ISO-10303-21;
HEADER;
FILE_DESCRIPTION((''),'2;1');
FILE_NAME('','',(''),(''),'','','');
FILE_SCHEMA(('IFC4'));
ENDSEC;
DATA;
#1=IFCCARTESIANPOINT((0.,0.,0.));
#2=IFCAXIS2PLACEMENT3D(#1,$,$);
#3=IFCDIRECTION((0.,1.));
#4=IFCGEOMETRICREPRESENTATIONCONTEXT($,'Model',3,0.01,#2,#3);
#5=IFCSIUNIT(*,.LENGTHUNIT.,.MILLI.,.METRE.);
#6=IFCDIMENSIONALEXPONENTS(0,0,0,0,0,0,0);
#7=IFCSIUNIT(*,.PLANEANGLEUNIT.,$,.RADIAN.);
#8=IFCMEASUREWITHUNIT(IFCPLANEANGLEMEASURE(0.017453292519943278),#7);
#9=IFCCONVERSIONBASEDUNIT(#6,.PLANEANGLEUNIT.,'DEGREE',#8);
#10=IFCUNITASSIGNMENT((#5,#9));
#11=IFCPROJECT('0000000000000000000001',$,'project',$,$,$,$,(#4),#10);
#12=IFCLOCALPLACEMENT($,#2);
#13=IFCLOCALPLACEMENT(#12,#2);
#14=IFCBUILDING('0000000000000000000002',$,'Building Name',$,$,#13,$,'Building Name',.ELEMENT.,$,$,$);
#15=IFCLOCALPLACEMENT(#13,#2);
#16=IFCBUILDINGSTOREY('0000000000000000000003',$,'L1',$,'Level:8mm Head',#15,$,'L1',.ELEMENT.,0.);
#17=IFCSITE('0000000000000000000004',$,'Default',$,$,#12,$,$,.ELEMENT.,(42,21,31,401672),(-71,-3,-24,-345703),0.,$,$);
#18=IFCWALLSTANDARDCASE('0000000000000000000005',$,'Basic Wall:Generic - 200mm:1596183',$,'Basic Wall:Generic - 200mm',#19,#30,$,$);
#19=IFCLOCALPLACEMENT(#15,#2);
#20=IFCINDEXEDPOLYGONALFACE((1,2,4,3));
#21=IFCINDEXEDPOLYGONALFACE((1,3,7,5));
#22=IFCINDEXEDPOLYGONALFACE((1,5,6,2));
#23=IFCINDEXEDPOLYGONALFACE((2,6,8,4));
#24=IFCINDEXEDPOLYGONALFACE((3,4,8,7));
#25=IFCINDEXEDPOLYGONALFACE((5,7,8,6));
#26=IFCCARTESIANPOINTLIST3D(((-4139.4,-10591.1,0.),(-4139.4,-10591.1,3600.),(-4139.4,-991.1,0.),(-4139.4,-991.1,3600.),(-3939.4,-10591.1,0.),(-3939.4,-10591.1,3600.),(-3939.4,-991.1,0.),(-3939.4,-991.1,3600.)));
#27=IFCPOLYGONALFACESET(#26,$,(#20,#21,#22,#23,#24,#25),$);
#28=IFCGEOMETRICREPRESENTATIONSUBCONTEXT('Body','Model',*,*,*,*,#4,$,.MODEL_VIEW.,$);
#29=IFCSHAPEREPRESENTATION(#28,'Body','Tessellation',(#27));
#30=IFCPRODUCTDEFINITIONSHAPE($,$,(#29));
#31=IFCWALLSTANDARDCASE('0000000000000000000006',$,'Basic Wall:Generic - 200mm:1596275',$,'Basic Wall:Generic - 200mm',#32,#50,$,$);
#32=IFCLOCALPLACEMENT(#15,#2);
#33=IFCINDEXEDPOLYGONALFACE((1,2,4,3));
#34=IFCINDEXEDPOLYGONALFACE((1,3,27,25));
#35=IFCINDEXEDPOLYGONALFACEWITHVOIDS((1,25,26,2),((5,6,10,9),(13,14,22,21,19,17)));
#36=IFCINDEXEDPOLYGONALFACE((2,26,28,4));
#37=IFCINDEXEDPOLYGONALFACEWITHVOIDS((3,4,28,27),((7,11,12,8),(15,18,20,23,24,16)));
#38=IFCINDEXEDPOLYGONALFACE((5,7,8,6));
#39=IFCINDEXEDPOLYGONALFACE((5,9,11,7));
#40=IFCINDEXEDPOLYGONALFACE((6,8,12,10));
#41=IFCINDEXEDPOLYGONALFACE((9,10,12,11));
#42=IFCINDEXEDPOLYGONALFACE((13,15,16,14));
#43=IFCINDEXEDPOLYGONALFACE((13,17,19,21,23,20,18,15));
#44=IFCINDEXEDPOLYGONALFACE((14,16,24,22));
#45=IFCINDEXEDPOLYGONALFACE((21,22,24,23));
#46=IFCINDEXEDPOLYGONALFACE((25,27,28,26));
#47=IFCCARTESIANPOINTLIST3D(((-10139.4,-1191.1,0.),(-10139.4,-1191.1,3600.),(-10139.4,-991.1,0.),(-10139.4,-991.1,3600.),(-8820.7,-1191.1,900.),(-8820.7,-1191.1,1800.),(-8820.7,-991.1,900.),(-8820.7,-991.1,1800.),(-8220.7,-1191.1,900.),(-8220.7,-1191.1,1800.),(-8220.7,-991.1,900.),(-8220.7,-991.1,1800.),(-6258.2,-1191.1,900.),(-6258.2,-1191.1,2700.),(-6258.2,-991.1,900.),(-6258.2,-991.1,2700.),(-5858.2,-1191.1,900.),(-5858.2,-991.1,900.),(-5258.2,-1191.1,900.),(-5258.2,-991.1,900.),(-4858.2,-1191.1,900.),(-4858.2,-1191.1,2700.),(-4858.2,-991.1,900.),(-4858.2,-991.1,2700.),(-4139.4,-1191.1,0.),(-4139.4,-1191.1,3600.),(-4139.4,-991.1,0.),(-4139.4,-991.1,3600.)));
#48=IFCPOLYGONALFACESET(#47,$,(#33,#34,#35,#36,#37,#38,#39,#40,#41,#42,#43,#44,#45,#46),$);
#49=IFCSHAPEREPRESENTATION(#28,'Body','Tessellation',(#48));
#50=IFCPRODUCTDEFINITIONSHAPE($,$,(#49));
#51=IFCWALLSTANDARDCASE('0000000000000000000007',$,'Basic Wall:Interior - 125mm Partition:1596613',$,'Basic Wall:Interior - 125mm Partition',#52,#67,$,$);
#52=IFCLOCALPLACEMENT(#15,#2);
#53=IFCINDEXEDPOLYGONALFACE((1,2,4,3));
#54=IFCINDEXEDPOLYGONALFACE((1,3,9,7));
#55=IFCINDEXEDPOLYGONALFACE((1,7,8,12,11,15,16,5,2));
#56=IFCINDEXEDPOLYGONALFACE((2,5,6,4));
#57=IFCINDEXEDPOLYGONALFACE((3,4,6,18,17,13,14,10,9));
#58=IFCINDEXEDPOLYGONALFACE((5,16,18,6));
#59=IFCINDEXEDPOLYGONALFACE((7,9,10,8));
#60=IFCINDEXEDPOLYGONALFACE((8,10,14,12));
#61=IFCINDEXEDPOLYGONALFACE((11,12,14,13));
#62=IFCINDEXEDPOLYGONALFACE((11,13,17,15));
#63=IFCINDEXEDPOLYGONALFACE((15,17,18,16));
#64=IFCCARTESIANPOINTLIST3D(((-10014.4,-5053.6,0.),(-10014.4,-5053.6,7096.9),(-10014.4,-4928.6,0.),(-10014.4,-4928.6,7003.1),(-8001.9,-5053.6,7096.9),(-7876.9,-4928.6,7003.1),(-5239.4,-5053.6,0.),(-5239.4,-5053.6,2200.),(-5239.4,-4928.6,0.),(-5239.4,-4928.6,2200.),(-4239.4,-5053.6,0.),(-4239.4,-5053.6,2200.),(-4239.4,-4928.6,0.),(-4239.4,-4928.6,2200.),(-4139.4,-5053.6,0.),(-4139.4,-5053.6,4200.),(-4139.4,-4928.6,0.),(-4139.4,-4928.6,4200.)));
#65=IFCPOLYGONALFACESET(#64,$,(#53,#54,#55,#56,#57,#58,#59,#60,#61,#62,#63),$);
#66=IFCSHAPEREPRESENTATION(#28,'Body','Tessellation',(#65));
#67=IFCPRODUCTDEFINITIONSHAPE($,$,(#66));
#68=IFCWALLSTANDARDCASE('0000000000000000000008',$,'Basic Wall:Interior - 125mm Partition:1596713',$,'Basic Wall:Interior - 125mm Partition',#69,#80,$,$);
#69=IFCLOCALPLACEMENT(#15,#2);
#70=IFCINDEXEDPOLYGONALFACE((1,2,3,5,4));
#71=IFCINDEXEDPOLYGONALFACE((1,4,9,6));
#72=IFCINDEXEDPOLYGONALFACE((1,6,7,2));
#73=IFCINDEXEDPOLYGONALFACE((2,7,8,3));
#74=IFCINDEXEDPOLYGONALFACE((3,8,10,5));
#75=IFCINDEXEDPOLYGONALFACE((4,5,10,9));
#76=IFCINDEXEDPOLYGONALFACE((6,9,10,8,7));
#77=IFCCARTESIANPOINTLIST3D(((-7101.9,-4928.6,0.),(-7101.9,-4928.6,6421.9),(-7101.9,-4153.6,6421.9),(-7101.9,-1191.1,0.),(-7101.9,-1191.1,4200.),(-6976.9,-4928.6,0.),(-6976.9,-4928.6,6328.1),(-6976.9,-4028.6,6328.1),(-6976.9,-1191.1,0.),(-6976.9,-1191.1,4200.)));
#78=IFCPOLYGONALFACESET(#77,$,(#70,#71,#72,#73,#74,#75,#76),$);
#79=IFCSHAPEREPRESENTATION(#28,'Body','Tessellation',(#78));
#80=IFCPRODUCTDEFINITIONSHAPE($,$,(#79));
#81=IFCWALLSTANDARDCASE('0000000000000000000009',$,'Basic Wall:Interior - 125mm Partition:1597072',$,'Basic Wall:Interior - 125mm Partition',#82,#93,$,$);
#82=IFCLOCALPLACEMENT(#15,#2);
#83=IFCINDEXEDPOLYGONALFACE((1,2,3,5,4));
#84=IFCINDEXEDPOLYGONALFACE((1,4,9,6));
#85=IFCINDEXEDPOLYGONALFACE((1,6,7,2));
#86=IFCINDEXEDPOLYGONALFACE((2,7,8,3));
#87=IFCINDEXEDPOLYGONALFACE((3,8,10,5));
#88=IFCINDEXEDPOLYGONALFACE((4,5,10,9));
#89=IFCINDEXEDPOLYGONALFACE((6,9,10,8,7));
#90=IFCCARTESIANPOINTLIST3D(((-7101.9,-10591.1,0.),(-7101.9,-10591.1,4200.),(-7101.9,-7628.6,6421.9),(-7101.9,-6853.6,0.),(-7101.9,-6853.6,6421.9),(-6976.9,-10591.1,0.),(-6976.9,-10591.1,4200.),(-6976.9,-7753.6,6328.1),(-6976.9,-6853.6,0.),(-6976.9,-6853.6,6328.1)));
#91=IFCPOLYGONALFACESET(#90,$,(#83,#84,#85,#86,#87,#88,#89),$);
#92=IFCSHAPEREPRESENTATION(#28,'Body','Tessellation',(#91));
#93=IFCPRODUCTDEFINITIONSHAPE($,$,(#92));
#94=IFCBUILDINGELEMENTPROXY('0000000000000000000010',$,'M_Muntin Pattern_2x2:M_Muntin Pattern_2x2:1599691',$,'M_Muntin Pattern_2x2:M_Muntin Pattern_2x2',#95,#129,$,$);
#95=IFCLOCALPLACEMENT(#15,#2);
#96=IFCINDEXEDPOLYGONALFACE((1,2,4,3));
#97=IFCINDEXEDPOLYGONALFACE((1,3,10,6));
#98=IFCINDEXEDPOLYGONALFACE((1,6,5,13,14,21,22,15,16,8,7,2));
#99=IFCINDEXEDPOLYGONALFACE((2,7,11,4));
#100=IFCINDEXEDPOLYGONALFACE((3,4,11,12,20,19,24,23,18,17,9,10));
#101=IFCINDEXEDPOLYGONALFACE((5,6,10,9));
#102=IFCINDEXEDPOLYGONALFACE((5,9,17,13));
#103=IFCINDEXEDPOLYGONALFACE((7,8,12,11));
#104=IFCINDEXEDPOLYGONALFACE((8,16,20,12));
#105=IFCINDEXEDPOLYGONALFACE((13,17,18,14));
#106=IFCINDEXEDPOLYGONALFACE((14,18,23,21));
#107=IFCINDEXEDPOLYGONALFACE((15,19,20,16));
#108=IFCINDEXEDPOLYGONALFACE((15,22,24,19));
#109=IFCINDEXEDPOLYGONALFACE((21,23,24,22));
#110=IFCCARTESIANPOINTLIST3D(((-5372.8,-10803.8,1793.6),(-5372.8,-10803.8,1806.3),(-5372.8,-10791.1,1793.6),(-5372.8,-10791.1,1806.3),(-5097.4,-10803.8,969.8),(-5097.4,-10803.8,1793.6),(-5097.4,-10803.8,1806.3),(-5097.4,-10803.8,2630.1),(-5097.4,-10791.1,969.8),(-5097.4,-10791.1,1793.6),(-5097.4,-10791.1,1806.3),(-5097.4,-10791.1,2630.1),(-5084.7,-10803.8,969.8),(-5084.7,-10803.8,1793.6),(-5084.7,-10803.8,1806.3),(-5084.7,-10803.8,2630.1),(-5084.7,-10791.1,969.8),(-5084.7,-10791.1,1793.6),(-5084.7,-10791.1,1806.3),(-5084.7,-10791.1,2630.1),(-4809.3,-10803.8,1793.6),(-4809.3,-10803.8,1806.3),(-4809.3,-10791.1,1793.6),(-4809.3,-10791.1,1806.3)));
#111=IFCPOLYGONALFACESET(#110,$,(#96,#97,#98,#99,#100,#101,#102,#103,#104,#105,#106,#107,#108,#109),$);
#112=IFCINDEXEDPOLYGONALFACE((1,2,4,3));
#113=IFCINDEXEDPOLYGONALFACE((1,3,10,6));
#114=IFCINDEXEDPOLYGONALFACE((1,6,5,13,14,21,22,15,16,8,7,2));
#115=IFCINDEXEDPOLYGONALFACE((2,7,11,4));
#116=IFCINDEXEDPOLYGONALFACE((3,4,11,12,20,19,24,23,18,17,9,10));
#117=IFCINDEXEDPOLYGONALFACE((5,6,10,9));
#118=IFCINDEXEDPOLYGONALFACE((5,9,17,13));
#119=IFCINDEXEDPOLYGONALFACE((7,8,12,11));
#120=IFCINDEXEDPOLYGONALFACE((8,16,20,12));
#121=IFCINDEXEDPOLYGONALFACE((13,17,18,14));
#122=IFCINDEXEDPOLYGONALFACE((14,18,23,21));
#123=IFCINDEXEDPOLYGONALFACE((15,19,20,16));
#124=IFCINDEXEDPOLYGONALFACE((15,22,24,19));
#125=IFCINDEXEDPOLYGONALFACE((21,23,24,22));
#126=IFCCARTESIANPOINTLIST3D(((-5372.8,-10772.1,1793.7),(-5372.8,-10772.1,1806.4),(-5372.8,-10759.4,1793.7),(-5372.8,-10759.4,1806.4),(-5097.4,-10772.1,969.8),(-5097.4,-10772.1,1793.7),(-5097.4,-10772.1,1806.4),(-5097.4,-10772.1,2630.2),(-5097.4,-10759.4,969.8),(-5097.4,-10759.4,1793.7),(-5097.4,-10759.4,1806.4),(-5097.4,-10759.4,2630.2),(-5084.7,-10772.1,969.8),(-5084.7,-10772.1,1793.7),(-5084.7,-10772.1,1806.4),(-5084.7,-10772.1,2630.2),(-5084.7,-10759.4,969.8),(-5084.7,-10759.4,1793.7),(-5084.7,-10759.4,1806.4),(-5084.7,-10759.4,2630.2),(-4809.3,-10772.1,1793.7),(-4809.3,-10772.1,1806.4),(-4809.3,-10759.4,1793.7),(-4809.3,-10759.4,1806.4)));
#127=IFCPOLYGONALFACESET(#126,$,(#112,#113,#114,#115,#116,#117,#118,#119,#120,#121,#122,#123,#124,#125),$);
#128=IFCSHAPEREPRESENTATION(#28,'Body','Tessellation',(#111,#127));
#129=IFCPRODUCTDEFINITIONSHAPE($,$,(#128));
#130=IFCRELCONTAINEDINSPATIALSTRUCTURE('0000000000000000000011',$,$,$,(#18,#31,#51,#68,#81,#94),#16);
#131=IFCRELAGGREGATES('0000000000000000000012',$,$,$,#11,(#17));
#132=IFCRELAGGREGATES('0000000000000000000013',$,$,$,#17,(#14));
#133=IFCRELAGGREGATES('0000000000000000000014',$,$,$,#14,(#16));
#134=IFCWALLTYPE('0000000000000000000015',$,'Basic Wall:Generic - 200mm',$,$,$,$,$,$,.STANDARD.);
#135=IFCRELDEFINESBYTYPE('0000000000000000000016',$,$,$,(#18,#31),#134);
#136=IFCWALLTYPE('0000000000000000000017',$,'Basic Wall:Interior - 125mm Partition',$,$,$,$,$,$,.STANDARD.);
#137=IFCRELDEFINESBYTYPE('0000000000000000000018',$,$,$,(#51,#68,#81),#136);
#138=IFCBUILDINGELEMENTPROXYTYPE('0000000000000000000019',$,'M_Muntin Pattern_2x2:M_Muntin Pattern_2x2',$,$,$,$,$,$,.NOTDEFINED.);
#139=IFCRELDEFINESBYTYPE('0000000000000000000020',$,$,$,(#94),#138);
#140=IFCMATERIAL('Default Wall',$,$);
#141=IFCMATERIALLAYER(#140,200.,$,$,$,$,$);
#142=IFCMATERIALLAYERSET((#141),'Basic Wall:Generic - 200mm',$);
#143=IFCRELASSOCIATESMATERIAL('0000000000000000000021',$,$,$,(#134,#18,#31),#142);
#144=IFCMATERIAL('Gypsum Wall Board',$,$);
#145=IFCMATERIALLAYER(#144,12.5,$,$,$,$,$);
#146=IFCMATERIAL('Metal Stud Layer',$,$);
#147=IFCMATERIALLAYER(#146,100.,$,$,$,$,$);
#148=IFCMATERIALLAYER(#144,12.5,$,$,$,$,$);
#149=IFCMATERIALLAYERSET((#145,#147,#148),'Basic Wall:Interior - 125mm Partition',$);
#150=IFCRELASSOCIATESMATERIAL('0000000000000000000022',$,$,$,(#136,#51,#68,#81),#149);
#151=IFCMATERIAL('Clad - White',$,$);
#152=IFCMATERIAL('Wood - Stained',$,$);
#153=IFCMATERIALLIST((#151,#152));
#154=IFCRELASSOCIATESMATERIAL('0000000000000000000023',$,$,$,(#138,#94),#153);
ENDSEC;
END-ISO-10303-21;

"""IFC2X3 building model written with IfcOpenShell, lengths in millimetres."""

from ifc_helpers import new_model, entity, si_unit, converted_unit, direction, frame, frame_2d, origin, place, context, subcontext, project, spatial, polyline, rectangle, outline, extrude, clip, bounded_halfspace, source, transform, mapped, material, material_list, layer, layer_set, layer_usage, type_object, type_shapes, element, save


model = new_model("IFC2X3")

# Units and contexts
model_context = context("Model", 3, precision=0.01, world=origin(), true_north=direction((0.0, 1.0)))
body_context = subcontext(model_context, "Body", "Model", "MODEL_VIEW")
ifc_project = project(units=[si_unit("LENGTHUNIT", "METRE", prefix="MILLI"), converted_unit("PLANEANGLEUNIT", "DEGREE", entity("IfcPlaneAngleMeasure", 0.017453292519943278), si_unit("PLANEANGLEUNIT", "RADIAN"), dimensions=[0, 0, 0, 0, 0, 0, 0])], contexts=[model_context])

# Site, building, storey
site_placement = place(None, origin())
site = spatial("IfcSite", under=ifc_project, at=site_placement, Name="Default", CompositionType="ELEMENT", RefLatitude=(42, 21, 31, 401672), RefLongitude=(-71, -3, -24, -345703), RefElevation=0.0)
building_placement = place(site_placement, origin())
building = spatial("IfcBuilding", under=site, at=building_placement, Name="Building Name", LongName="Building Name", CompositionType="ELEMENT")
storey_placement = place(building_placement, origin())
storey = spatial("IfcBuildingStorey", under=building, at=storey_placement, Name="L1", ObjectType="Level:8mm Head", LongName="L1", CompositionType="ELEMENT", Elevation=0.0)

# Wall
ifc_material_1 = material(Name="Default Wall")
ifc_layer_1 = layer(ifc_material_1, 200.0)
ifc_layer_set_1 = layer_set([ifc_layer_1], Name="Basic Wall:Generic - 200mm")
ifc_layer_usage_1 = layer_usage(ifc_layer_set_1, "AXIS2", "NEGATIVE", 100.0)
wall_type_1 = type_object("IfcWallType", Name="Basic Wall:Generic - 200mm", PredefinedType="STANDARD", material=ifc_layer_set_1)
wall_1_placement = place(storey_placement, frame((-4039.4, -10591.1, 0.0), z_axis=(0.0, 0.0, 1.0), x_axis=(0.0, 1.0, 0.0)))
element("IfcWallStandardCase", 1, at=wall_1_placement, inside=storey, type_object=wall_type_1, material=ifc_layer_usage_1, Name="Basic Wall:Generic - 200mm:1596183", ObjectType="Basic Wall:Generic - 200mm", context=body_context, shape_type="SweptSolid", body=[
    extrude(rectangle(XDim=9600.0, YDim=200.0, at=frame_2d((4800.0, 0.0), x_axis=(-1.0, 0.0))), origin(), (0.0, 0.0, 1.0), 3600.0),
])

# Wall, openings
wall_2_placement = place(storey_placement, frame((-4139.4, -1091.1, 0.0), z_axis=(0.0, 0.0, 1.0), x_axis=(-1.0, 0.0, 0.0)))
wall_2 = element("IfcWallStandardCase", 2, at=wall_2_placement, inside=storey, type_object=wall_type_1, material=ifc_layer_usage_1, Name="Basic Wall:Generic - 200mm:1596275", ObjectType="Basic Wall:Generic - 200mm", context=body_context, shape_type="SweptSolid", body=[
    extrude(rectangle(XDim=6000.0, YDim=200.0, at=frame_2d((3000.0, 0.0), x_axis=(-1.0, 0.0))), origin(), (0.0, 0.0, 1.0), 3600.0),
])
opening_1_placement = place(wall_2_placement, frame((2118.8, 100.0, 900.0)))
element("IfcOpeningElement", 3, at=opening_1_placement, cuts=wall_2, ObjectType="Opening", context=body_context, shape_type="SweptSolid", body=[
    extrude(rectangle(XDim=1800.0, YDim=1400.0, at=frame_2d((900.0, 700.0), x_axis=(-1.0, 0.0))), frame((0.0, 0.0, 0.0), z_axis=(0.0, -1.0, 0.0), x_axis=(0.0, 0.0, 1.0)), (0.0, 0.0, 1.0), 200.0),
])
opening_2_placement = place(wall_2_placement, frame((1118.8, -100.0, 900.0)))
element("IfcOpeningElement", 4, at=opening_2_placement, cuts=wall_2, ObjectType="Opening", context=body_context, shape_type="SweptSolid", body=[
    extrude(rectangle(XDim=900.0, YDim=600.0, at=frame_2d((450.0, 300.0), x_axis=(-1.0, 0.0))), frame((0.0, 0.0, 0.0), z_axis=(0.0, 1.0, 0.0), x_axis=(0.0, 0.0, 1.0)), (0.0, 0.0, 1.0), 200.0),
])
opening_3_placement = place(wall_2_placement, frame((4081.3, -100.0, 900.0)))
element("IfcOpeningElement", 5, at=opening_3_placement, cuts=wall_2, ObjectType="Opening", context=body_context, shape_type="SweptSolid", body=[
    extrude(rectangle(XDim=900.0, YDim=600.0, at=frame_2d((450.0, 300.0), x_axis=(-1.0, 0.0))), frame((0.0, 0.0, 0.0), z_axis=(0.0, 1.0, 0.0), x_axis=(0.0, 0.0, 1.0)), (0.0, 0.0, 1.0), 200.0),
])

# Wall, opening
ifc_material_2 = material(Name="Gypsum Wall Board")
ifc_layer_2 = layer(ifc_material_2, 12.5)
ifc_material_3 = material(Name="Metal Stud Layer")
ifc_layer_3 = layer(ifc_material_3, 100.0)
ifc_layer_4 = layer(ifc_material_2, 12.5)
ifc_layer_set_2 = layer_set([ifc_layer_2, ifc_layer_3, ifc_layer_4], Name="Basic Wall:Interior - 125mm Partition")
ifc_layer_usage_2 = layer_usage(ifc_layer_set_2, "AXIS2", "NEGATIVE", 62.5)
wall_type_2 = type_object("IfcWallType", Name="Basic Wall:Interior - 125mm Partition", PredefinedType="STANDARD", material=ifc_layer_set_2)
wall_3_placement = place(storey_placement, frame((-10014.4, -4991.1, 0.0)))
wall_3 = element("IfcWallStandardCase", 6, at=wall_3_placement, inside=storey, type_object=wall_type_2, material=ifc_layer_usage_2, Name="Basic Wall:Interior - 125mm Partition:1596613", ObjectType="Basic Wall:Interior - 125mm Partition", context=body_context, shape_type="Clipping", body=[
    clip(clip(extrude(rectangle(XDim=125.0, YDim=5875.0, at=frame_2d((2937.5, 0.0), x_axis=(0.0, 1.0))), origin(), (0.0, 0.0, 1.0), 7096.9), bounded_halfspace(frame((5875.0, -62.5, 4200.0), z_axis=(0.6, 0.0, 0.8), x_axis=(0.0, 1.0, 0.0)), False, frame((5875.0, -62.5, 4200.0)), polyline([(0.0, 0.0), (0.0, 125.0), (-2837.5, 125.0), (-2962.5, 125.0), (-3737.5, 125.0), (-3862.5, 0.0), (0.0, 0.0)]))), bounded_halfspace(frame((0.0, 62.5, 7003.1), z_axis=(0.0, 0.6, 0.8), x_axis=(-1.0, 0.0, 0.0)), False, frame((0.0, 62.5, 7003.1)), polyline([(0.0, 0.0), (0.0, -125.0), (2012.5, -125.0), (2137.5, 0.0), (0.0, 0.0)]))),
])
opening_4_placement = place(wall_3_placement, frame((4775.0, -62.5, 0.0)))
element("IfcOpeningElement", 7, at=opening_4_placement, cuts=wall_3, ObjectType="Opening", context=body_context, shape_type="SweptSolid", body=[
    extrude(rectangle(XDim=2200.0, YDim=1000.0, at=frame_2d((1100.0, 500.0), x_axis=(1.0, 0.0))), frame((0.0, 0.0, 0.0), z_axis=(0.0, 1.0, 0.0), x_axis=(0.0, 0.0, 1.0)), (0.0, 0.0, 1.0), 125.0),
])

# Walls
wall_4_placement = place(storey_placement, frame((-7039.4, -4928.6, 0.0), z_axis=(0.0, 0.0, 1.0), x_axis=(0.0, 1.0, 0.0)))
element("IfcWallStandardCase", 8, at=wall_4_placement, inside=storey, type_object=wall_type_2, material=ifc_layer_usage_2, Name="Basic Wall:Interior - 125mm Partition:1596713", ObjectType="Basic Wall:Interior - 125mm Partition", context=body_context, shape_type="Clipping", body=[
    clip(clip(extrude(rectangle(XDim=3737.5, YDim=125.0, at=frame_2d((1868.8, 0.0), x_axis=(-1.0, 0.0))), origin(), (0.0, 0.0, 1.0), 6421.9), bounded_halfspace(frame((0.0, -62.5, 6328.1), z_axis=(0.0, -0.6, 0.8), x_axis=(1.0, 0.0, 0.0)), False, frame((0.0, -62.5, 6328.1)), polyline([(0.0, 0.0), (900.0, 0.0), (775.0, 125.0), (0.0, 125.0), (0.0, 0.0)]))), bounded_halfspace(frame((900.0, -62.5, 6328.1), z_axis=(0.6, 0.0, 0.8), x_axis=(0.0, 1.0, 0.0)), False, frame((900.0, -62.5, 6328.1)), polyline([(0.0, 0.0), (2837.5, 0.0), (2837.5, 125.0), (-125.0, 125.0), (0.0, 0.0)]))),
])
wall_5_placement = place(storey_placement, frame((-7039.4, -6853.6, 0.0), z_axis=(0.0, 0.0, 1.0), x_axis=(0.0, -1.0, 0.0)))
element("IfcWallStandardCase", 9, at=wall_5_placement, inside=storey, type_object=wall_type_2, material=ifc_layer_usage_2, Name="Basic Wall:Interior - 125mm Partition:1597072", ObjectType="Basic Wall:Interior - 125mm Partition", context=body_context, shape_type="Clipping", body=[
    clip(clip(extrude(rectangle(XDim=3737.5, YDim=125.0, at=frame_2d((1868.8, 0.0), x_axis=(-1.0, 0.0))), origin(), (0.0, 0.0, 1.0), 6421.9), bounded_halfspace(frame((775.0, -62.5, 6421.9), z_axis=(0.6, 0.0, 0.8), x_axis=(0.0, 1.0, 0.0)), False, frame((775.0, -62.5, 6421.9)), polyline([(0.0, 0.0), (2962.5, 0.0), (2962.5, 125.0), (125.0, 125.0), (0.0, 0.0)]))), bounded_halfspace(frame((0.0, -62.5, 6421.9), z_axis=(0.0, 0.6, 0.8), x_axis=(-1.0, 0.0, 0.0)), False, frame((0.0, -62.5, 6421.9)), polyline([(0.0, 0.0), (775.0, 0.0), (900.0, 125.0), (0.0, 125.0), (0.0, 0.0)]))),
])

# Building element proxy
ifc_material_4 = material(Name="Clad - White")
ifc_material_5 = material(Name="Wood - Stained")
ifc_material_list = material_list([ifc_material_4, ifc_material_5])
building_element_proxy_type_1 = type_object("IfcBuildingElementProxyType", Name="M_Muntin Pattern_2x2:M_Muntin Pattern_2x2", PredefinedType="NOTDEFINED", material=ifc_material_list)
shared_shape_1 = source(origin(), body_context, "Body", "SweptSolid", [
    extrude(outline(polyline([(6.4, -6.4), (830.1, -6.4), (830.1, 6.3), (6.4, 6.3), (6.4, 281.7), (-6.3, 281.7), (-6.3, 6.3), (-830.2, 6.3), (-830.2, -6.4), (-6.3, -6.4), (-6.3, -281.7), (6.4, -281.7), (6.4, -6.4)])), frame((0.0, 9.5, 830.1), z_axis=(0.0, 1.0, 0.0), x_axis=(0.0, 0.0, 1.0)), (0.0, 0.0, 1.0), 12.7),
    extrude(outline(polyline([(6.4, -6.4), (830.2, -6.4), (830.2, 6.3), (6.4, 6.3), (6.4, 281.7), (-6.3, 281.7), (-6.3, 6.3), (-830.2, 6.3), (-830.2, -6.4), (-6.3, -6.4), (-6.3, -281.7), (6.4, -281.7), (6.4, -6.4)])), frame((0.0, -22.2, 830.2), z_axis=(0.0, 1.0, 0.0), x_axis=(0.0, 0.0, 1.0)), (0.0, 0.0, 1.0), 12.7),
])
type_shapes(building_element_proxy_type_1, [shared_shape_1])
proxy_1_placement = place(storey_placement, frame((-5091.0, -10781.6, 969.8), z_axis=(0.0, 0.0, 1.0), x_axis=(-1.0, 0.0, 0.0)))
element("IfcBuildingElementProxy", 10, at=proxy_1_placement, inside=storey, type_object=building_element_proxy_type_1, material=ifc_material_list, Name="M_Muntin Pattern_2x2:M_Muntin Pattern_2x2:1599691", ObjectType="M_Muntin Pattern_2x2:M_Muntin Pattern_2x2", context=body_context, shape_type="MappedRepresentation", body=[
    mapped(shared_shape_1, transform((0.0, 0.0, 0.0), scale=1.0)),
])

save(model, "model.ifc")
